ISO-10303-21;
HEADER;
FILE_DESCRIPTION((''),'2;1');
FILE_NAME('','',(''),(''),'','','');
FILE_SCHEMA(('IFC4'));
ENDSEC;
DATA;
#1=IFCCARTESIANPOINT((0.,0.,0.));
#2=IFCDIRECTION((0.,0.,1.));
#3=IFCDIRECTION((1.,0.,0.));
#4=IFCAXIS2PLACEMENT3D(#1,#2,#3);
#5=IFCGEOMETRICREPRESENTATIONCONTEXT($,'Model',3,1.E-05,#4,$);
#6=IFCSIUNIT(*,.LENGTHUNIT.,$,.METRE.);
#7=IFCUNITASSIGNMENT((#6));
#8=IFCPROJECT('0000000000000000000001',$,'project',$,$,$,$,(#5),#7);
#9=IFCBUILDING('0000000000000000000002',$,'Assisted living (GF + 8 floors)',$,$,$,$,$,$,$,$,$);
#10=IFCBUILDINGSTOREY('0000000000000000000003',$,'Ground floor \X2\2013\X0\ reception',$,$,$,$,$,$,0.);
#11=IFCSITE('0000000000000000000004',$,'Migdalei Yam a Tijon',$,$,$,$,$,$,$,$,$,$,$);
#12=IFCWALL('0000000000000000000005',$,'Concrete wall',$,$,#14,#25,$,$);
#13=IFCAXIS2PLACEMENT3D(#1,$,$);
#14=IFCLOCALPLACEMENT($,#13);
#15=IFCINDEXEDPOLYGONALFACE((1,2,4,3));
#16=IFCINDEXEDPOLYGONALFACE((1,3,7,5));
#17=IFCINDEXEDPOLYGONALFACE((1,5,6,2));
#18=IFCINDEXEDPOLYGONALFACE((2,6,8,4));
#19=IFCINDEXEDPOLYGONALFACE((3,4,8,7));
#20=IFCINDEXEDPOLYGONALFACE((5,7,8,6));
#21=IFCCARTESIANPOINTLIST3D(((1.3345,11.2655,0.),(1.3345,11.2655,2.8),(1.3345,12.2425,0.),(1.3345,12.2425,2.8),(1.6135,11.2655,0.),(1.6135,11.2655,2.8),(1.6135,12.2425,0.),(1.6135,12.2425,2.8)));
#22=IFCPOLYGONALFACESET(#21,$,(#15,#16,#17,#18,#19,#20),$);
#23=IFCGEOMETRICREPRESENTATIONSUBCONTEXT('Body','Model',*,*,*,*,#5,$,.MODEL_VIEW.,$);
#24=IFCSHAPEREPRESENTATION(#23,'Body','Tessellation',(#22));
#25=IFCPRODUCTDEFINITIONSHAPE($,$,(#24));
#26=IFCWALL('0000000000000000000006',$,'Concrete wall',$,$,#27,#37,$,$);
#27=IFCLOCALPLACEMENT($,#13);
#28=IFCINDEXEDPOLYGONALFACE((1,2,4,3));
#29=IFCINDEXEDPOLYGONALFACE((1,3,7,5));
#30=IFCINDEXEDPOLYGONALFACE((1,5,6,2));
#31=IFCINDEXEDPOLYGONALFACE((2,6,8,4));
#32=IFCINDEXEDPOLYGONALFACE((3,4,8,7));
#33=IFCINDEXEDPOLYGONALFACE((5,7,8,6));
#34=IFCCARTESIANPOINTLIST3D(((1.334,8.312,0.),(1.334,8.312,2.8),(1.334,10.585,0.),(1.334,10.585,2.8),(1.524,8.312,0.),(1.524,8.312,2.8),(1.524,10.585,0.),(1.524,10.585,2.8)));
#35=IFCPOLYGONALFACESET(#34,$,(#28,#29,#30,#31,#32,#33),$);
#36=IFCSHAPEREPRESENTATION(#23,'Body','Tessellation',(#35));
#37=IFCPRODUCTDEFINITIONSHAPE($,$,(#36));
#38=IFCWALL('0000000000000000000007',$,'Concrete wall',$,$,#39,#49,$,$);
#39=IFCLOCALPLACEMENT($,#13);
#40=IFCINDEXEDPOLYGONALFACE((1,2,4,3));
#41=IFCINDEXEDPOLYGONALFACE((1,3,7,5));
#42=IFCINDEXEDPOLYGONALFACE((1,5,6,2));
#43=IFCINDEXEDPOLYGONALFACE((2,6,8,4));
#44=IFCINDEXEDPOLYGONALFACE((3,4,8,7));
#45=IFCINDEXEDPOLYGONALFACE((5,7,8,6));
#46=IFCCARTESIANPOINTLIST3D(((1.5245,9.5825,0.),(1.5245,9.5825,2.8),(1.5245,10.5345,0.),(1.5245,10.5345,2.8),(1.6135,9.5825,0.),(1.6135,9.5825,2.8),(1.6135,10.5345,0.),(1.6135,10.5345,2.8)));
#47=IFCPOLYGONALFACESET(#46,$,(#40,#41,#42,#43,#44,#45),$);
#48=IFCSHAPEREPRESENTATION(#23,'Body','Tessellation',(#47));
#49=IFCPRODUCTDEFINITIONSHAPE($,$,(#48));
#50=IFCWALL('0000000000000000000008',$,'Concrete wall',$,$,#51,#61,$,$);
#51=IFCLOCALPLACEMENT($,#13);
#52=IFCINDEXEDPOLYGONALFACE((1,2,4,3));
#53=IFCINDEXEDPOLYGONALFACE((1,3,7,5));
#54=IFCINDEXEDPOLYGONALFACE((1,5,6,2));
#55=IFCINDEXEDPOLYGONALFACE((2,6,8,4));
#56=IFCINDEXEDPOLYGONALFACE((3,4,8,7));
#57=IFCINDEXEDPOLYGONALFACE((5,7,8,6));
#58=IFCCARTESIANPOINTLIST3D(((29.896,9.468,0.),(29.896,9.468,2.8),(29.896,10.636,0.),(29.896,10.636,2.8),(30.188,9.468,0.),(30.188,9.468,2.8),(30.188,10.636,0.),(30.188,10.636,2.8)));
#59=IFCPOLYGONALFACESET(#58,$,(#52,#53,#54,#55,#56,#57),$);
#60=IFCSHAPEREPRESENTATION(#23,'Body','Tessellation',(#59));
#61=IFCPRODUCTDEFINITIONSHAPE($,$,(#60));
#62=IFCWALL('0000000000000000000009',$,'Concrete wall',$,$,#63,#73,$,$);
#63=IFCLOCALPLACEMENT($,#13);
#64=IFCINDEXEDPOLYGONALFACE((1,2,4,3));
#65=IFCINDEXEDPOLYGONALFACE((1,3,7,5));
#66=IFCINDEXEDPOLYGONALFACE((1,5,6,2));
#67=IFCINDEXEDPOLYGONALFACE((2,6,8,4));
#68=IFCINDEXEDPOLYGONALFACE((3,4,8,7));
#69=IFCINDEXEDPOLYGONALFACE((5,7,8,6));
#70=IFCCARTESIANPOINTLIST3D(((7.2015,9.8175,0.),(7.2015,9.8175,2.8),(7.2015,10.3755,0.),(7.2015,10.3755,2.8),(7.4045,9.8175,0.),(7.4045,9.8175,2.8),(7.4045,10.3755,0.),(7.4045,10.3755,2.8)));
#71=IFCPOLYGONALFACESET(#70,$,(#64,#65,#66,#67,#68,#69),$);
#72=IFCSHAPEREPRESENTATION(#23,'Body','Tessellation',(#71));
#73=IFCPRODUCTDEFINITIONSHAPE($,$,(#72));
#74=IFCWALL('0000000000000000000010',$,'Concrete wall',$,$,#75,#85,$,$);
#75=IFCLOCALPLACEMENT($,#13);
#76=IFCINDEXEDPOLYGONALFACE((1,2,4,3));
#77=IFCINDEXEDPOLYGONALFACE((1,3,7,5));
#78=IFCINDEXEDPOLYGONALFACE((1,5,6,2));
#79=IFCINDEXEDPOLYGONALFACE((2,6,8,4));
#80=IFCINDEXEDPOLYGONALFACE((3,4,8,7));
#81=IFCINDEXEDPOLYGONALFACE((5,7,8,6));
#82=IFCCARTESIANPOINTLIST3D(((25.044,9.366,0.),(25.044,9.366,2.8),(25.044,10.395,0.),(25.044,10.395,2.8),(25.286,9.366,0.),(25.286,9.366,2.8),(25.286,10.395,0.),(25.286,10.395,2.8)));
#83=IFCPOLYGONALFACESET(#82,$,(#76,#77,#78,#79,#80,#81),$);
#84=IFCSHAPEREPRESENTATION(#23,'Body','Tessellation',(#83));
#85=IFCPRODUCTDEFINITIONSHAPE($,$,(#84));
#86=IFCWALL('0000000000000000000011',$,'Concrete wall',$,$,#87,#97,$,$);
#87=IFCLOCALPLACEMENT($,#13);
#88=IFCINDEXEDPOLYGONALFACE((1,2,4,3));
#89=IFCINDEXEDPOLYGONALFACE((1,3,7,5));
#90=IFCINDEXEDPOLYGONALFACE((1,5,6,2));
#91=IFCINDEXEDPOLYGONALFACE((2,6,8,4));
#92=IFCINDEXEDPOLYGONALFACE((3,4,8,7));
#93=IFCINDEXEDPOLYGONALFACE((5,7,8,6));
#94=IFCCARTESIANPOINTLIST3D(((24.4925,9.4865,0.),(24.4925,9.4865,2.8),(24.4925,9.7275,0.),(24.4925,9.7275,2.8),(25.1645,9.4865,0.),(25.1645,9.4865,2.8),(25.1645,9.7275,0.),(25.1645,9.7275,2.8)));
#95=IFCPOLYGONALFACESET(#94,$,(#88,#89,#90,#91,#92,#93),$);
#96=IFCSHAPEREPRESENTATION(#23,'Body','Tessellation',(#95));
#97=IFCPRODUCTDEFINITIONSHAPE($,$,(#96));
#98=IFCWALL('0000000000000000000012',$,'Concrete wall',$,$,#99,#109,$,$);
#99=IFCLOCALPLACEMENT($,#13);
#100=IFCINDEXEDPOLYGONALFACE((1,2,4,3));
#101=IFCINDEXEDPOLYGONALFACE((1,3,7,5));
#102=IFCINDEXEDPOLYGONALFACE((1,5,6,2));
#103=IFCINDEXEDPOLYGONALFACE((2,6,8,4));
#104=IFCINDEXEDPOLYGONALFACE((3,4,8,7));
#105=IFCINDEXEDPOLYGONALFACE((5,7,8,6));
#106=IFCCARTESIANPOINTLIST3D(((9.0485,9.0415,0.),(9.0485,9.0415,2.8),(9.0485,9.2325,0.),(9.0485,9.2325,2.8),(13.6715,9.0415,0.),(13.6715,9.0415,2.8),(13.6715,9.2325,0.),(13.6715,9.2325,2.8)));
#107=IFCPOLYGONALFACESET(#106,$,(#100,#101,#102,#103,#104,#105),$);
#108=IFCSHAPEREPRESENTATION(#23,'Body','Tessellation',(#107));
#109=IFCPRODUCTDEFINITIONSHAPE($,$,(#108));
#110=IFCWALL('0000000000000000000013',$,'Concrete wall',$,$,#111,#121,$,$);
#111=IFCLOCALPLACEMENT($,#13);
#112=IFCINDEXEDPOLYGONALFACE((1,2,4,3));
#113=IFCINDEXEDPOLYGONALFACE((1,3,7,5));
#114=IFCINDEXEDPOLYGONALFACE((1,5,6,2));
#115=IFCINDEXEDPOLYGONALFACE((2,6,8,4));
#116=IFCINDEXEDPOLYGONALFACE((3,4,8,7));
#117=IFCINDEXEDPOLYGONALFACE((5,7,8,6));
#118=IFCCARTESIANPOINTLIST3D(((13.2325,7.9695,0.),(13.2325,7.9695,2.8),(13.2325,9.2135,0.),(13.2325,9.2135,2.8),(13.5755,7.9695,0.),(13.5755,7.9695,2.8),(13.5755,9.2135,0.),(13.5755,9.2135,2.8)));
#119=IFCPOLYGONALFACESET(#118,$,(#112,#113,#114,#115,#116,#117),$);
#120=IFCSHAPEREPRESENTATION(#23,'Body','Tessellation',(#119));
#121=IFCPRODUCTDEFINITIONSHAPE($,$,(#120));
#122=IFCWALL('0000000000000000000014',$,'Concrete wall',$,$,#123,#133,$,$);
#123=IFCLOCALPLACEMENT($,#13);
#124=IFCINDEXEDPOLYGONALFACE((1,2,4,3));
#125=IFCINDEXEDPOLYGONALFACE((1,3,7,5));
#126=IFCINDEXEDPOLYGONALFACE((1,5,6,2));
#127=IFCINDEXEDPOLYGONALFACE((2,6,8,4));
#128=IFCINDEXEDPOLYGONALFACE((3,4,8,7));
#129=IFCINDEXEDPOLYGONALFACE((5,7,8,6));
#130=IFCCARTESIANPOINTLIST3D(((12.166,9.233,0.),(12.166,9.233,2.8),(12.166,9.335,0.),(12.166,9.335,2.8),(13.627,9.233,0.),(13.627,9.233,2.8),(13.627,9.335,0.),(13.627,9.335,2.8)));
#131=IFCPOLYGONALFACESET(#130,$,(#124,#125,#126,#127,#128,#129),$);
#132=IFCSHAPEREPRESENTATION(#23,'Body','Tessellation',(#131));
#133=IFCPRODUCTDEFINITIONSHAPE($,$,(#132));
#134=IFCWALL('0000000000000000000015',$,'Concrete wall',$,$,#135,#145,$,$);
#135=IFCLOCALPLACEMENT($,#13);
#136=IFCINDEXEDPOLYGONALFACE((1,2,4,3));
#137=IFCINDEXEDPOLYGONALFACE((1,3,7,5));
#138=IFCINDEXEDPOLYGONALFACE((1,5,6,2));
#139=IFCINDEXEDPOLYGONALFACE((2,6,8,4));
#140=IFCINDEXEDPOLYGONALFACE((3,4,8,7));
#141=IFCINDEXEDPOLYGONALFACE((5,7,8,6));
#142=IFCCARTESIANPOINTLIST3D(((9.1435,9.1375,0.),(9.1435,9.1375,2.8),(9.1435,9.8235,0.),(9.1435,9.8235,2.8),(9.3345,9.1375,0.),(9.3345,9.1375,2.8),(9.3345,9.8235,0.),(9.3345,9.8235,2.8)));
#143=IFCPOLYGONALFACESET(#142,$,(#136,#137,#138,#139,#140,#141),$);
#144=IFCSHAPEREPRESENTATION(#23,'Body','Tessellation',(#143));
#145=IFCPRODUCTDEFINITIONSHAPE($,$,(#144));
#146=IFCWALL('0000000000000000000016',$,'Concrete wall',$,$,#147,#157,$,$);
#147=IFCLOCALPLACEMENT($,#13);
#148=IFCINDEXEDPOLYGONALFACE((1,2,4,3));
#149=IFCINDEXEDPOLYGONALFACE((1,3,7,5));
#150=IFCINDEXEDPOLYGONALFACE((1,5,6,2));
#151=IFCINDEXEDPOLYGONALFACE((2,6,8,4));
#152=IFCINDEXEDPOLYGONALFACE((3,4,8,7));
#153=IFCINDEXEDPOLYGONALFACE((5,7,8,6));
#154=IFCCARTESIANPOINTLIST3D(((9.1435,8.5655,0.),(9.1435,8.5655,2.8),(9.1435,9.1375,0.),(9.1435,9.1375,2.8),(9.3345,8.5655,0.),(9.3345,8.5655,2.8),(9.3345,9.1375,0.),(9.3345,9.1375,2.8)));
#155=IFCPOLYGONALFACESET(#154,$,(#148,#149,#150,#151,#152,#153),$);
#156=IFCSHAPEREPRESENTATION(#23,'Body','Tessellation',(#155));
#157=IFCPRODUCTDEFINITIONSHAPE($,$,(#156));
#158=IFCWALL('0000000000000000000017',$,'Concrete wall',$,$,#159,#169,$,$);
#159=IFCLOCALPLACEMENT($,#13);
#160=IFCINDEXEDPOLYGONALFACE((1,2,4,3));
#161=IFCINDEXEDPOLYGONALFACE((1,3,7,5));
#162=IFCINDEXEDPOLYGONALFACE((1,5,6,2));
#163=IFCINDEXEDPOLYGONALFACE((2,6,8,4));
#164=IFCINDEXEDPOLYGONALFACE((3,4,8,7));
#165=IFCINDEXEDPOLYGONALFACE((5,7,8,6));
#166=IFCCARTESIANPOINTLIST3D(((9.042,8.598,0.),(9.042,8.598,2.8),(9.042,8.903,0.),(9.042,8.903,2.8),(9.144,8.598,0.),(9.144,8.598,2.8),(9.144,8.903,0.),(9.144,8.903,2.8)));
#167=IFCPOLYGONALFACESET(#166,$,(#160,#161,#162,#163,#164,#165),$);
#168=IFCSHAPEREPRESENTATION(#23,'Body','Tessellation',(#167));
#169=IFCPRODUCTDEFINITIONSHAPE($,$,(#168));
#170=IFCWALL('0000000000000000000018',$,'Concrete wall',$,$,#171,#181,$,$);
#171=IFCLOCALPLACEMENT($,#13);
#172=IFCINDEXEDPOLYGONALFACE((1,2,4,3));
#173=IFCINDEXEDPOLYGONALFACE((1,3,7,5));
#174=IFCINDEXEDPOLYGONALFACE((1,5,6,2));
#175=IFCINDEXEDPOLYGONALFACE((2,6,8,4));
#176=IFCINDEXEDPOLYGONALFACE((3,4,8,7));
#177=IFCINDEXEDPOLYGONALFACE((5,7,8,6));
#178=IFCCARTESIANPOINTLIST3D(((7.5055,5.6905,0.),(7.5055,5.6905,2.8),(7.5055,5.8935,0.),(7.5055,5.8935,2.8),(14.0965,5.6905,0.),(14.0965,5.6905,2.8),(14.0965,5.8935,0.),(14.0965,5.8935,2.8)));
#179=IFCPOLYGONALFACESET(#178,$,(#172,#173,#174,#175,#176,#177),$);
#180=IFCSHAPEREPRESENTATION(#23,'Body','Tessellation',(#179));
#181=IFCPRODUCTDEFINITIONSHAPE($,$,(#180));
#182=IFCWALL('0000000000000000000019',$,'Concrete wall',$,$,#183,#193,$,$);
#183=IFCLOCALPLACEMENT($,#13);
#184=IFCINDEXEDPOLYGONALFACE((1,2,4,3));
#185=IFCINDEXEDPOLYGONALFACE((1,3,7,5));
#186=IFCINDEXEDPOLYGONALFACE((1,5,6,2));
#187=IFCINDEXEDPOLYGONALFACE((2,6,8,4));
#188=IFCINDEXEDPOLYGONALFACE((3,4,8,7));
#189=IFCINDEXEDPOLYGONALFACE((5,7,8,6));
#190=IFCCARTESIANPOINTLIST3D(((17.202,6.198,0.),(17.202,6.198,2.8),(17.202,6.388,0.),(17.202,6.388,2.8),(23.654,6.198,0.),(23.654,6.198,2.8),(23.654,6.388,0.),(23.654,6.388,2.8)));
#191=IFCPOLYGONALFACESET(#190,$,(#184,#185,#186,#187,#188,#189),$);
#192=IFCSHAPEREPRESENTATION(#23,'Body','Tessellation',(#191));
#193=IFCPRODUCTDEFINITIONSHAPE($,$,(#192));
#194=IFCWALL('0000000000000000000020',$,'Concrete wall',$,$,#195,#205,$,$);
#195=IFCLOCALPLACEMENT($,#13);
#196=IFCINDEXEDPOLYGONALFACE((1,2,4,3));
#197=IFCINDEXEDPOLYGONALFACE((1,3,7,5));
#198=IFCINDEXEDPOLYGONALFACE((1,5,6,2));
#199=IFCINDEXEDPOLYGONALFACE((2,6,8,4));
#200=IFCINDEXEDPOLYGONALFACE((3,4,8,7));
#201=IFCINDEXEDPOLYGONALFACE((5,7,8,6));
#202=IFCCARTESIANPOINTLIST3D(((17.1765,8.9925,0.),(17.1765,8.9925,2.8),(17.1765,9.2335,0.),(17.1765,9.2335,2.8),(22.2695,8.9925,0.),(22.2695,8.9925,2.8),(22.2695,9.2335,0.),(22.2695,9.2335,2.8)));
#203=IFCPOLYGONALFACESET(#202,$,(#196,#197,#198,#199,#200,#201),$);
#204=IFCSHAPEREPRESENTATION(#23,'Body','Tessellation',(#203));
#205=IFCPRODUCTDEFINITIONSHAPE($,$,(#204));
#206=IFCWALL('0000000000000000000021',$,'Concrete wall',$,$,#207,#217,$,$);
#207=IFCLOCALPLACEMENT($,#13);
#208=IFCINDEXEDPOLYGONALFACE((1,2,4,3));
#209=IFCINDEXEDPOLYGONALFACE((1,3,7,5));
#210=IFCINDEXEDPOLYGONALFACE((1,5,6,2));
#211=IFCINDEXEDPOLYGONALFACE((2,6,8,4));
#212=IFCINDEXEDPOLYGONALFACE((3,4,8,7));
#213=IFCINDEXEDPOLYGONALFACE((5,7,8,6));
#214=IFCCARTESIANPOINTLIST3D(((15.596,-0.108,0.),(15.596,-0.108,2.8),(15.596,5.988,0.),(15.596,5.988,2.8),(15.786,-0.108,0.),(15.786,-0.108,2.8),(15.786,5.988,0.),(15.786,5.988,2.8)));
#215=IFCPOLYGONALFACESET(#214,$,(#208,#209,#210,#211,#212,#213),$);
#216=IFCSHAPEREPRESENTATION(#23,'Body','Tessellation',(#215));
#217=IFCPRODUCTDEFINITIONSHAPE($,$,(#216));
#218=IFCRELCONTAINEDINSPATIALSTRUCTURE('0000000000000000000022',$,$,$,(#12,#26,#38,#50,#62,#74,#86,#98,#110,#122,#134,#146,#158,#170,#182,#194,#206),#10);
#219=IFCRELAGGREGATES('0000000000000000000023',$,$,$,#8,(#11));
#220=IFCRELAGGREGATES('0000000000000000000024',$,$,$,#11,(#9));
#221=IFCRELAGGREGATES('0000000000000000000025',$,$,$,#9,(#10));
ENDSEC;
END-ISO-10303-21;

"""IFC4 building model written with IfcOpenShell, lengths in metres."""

from ifc_helpers import new_model, si_unit, frame, origin_with_axes, context, subcontext, project, spatial, line, indexed_curve, outline, extrude, element, save


model = new_model("IFC4")

# Units and contexts
model_context = context("Model", 3, precision=1e-05, world=origin_with_axes())
body_context = subcontext(model_context, "Body", "Model", "MODEL_VIEW")
ifc_project = project(units=[si_unit("LENGTHUNIT", "METRE")], contexts=[model_context])

# Site, building, storey
site = spatial("IfcSite", under=ifc_project, Name="Migdalei Yam a Tijon")
building = spatial("IfcBuilding", under=site, Name="Assisted living (GF + 8 floors)")
storey = spatial("IfcBuildingStorey", under=building, Name="Ground floor – reception", Elevation=0.0)

# Walls
element("IfcWall", 1, inside=storey, Name="Concrete wall", context=body_context, shape_type="SweptSolid", body=[
    extrude(outline(indexed_curve([(0.0, 0.0), (0.279, 0.0), (0.279, 0.977), (0.0, 0.977)], segments=[line(1, 2, 3, 4, 1)])), frame((1.3345, 11.2655, 0.0), z_axis=(0.0, 0.0, 1.0), x_axis=(1.0, 0.0, 0.0)), (0.0, 0.0, 1.0), 2.8),
])
element("IfcWall", 2, inside=storey, Name="Concrete wall", context=body_context, shape_type="SweptSolid", body=[
    extrude(outline(indexed_curve([(0.0, 0.0), (0.19, 0.0), (0.19, 2.273), (0.0, 2.273)], segments=[line(1, 2, 3, 4, 1)])), frame((1.334, 8.312, 0.0), z_axis=(0.0, 0.0, 1.0), x_axis=(1.0, 0.0, 0.0)), (0.0, 0.0, 1.0), 2.8),
])
element("IfcWall", 3, inside=storey, Name="Concrete wall", context=body_context, shape_type="SweptSolid", body=[
    extrude(outline(indexed_curve([(0.0, 0.0), (0.089, 0.0), (0.089, 0.952), (0.0, 0.952)], segments=[line(1, 2, 3, 4, 1)])), frame((1.5245, 9.5825, 0.0), z_axis=(0.0, 0.0, 1.0), x_axis=(1.0, 0.0, 0.0)), (0.0, 0.0, 1.0), 2.8),
])
element("IfcWall", 4, inside=storey, Name="Concrete wall", context=body_context, shape_type="SweptSolid", body=[
    extrude(outline(indexed_curve([(0.0, 0.0), (0.292, 0.0), (0.292, 1.168), (0.0, 1.168)], segments=[line(1, 2, 3, 4, 1)])), frame((29.896, 9.468, 0.0), z_axis=(0.0, 0.0, 1.0), x_axis=(1.0, 0.0, 0.0)), (0.0, 0.0, 1.0), 2.8),
])
element("IfcWall", 5, inside=storey, Name="Concrete wall", context=body_context, shape_type="SweptSolid", body=[
    extrude(outline(indexed_curve([(0.0, 0.0), (0.203, 0.0), (0.203, 0.558), (0.0, 0.558)], segments=[line(1, 2, 3, 4, 1)])), frame((7.2015, 9.8175, 0.0), z_axis=(0.0, 0.0, 1.0), x_axis=(1.0, 0.0, 0.0)), (0.0, 0.0, 1.0), 2.8),
])
element("IfcWall", 6, inside=storey, Name="Concrete wall", context=body_context, shape_type="SweptSolid", body=[
    extrude(outline(indexed_curve([(0.0, 0.0), (0.242, 0.0), (0.242, 1.029), (0.0, 1.029)], segments=[line(1, 2, 3, 4, 1)])), frame((25.044, 9.366, 0.0), z_axis=(0.0, 0.0, 1.0), x_axis=(1.0, 0.0, 0.0)), (0.0, 0.0, 1.0), 2.8),
])
element("IfcWall", 7, inside=storey, Name="Concrete wall", context=body_context, shape_type="SweptSolid", body=[
    extrude(outline(indexed_curve([(0.0, 0.0), (0.672, 0.0), (0.672, 0.241), (0.0, 0.241)], segments=[line(1, 2, 3, 4, 1)])), frame((24.4925, 9.4865, 0.0), z_axis=(0.0, 0.0, 1.0), x_axis=(1.0, 0.0, 0.0)), (0.0, 0.0, 1.0), 2.8),
])
element("IfcWall", 8, inside=storey, Name="Concrete wall", context=body_context, shape_type="SweptSolid", body=[
    extrude(outline(indexed_curve([(0.0, 0.0), (4.623, 0.0), (4.623, 0.191), (0.0, 0.191)], segments=[line(1, 2, 3, 4, 1)])), frame((9.0485, 9.0415, 0.0), z_axis=(0.0, 0.0, 1.0), x_axis=(1.0, 0.0, 0.0)), (0.0, 0.0, 1.0), 2.8),
])
element("IfcWall", 9, inside=storey, Name="Concrete wall", context=body_context, shape_type="SweptSolid", body=[
    extrude(outline(indexed_curve([(0.0, 0.0), (0.343, 0.0), (0.343, 1.244), (0.0, 1.244)], segments=[line(1, 2, 3, 4, 1)])), frame((13.2325, 7.9695, 0.0), z_axis=(0.0, 0.0, 1.0), x_axis=(1.0, 0.0, 0.0)), (0.0, 0.0, 1.0), 2.8),
])
element("IfcWall", 10, inside=storey, Name="Concrete wall", context=body_context, shape_type="SweptSolid", body=[
    extrude(outline(indexed_curve([(0.0, 0.0), (1.461, 0.0), (1.461, 0.102), (0.0, 0.102)], segments=[line(1, 2, 3, 4, 1)])), frame((12.166, 9.233, 0.0), z_axis=(0.0, 0.0, 1.0), x_axis=(1.0, 0.0, 0.0)), (0.0, 0.0, 1.0), 2.8),
])
element("IfcWall", 11, inside=storey, Name="Concrete wall", context=body_context, shape_type="SweptSolid", body=[
    extrude(outline(indexed_curve([(0.0, 0.0), (0.191, 0.0), (0.191, 0.686), (0.0, 0.686)], segments=[line(1, 2, 3, 4, 1)])), frame((9.1435, 9.1375, 0.0), z_axis=(0.0, 0.0, 1.0), x_axis=(1.0, 0.0, 0.0)), (0.0, 0.0, 1.0), 2.8),
])
element("IfcWall", 12, inside=storey, Name="Concrete wall", context=body_context, shape_type="SweptSolid", body=[
    extrude(outline(indexed_curve([(0.0, 0.0), (0.191, 0.0), (0.191, 0.572), (0.0, 0.572)], segments=[line(1, 2, 3, 4, 1)])), frame((9.1435, 8.5655, 0.0), z_axis=(0.0, 0.0, 1.0), x_axis=(1.0, 0.0, 0.0)), (0.0, 0.0, 1.0), 2.8),
])
element("IfcWall", 13, inside=storey, Name="Concrete wall", context=body_context, shape_type="SweptSolid", body=[
    extrude(outline(indexed_curve([(0.0, 0.0), (0.102, 0.0), (0.102, 0.305), (0.0, 0.305)], segments=[line(1, 2, 3, 4, 1)])), frame((9.042, 8.598, 0.0), z_axis=(0.0, 0.0, 1.0), x_axis=(1.0, 0.0, 0.0)), (0.0, 0.0, 1.0), 2.8),
])
element("IfcWall", 14, inside=storey, Name="Concrete wall", context=body_context, shape_type="SweptSolid", body=[
    extrude(outline(indexed_curve([(0.0, 0.0), (6.591, 0.0), (6.591, 0.203), (0.0, 0.203)], segments=[line(1, 2, 3, 4, 1)])), frame((7.5055, 5.6905, 0.0), z_axis=(0.0, 0.0, 1.0), x_axis=(1.0, 0.0, 0.0)), (0.0, 0.0, 1.0), 2.8),
])
element("IfcWall", 15, inside=storey, Name="Concrete wall", context=body_context, shape_type="SweptSolid", body=[
    extrude(outline(indexed_curve([(0.0, 0.0), (6.452, 0.0), (6.452, 0.19), (0.0, 0.19)], segments=[line(1, 2, 3, 4, 1)])), frame((17.202, 6.198, 0.0), z_axis=(0.0, 0.0, 1.0), x_axis=(1.0, 0.0, 0.0)), (0.0, 0.0, 1.0), 2.8),
])
element("IfcWall", 16, inside=storey, Name="Concrete wall", context=body_context, shape_type="SweptSolid", body=[
    extrude(outline(indexed_curve([(0.0, 0.0), (5.093, 0.0), (5.093, 0.241), (0.0, 0.241)], segments=[line(1, 2, 3, 4, 1)])), frame((17.1765, 8.9925, 0.0), z_axis=(0.0, 0.0, 1.0), x_axis=(1.0, 0.0, 0.0)), (0.0, 0.0, 1.0), 2.8),
])
element("IfcWall", 17, inside=storey, Name="Concrete wall", context=body_context, shape_type="SweptSolid", body=[
    extrude(outline(indexed_curve([(0.0, 0.0), (0.19, 0.0), (0.19, 6.096), (0.0, 6.096)], segments=[line(1, 2, 3, 4, 1)])), frame((15.596, -0.108, 0.0), z_axis=(0.0, 0.0, 1.0), x_axis=(1.0, 0.0, 0.0)), (0.0, 0.0, 1.0), 2.8),
])

save(model, "model.ifc")
